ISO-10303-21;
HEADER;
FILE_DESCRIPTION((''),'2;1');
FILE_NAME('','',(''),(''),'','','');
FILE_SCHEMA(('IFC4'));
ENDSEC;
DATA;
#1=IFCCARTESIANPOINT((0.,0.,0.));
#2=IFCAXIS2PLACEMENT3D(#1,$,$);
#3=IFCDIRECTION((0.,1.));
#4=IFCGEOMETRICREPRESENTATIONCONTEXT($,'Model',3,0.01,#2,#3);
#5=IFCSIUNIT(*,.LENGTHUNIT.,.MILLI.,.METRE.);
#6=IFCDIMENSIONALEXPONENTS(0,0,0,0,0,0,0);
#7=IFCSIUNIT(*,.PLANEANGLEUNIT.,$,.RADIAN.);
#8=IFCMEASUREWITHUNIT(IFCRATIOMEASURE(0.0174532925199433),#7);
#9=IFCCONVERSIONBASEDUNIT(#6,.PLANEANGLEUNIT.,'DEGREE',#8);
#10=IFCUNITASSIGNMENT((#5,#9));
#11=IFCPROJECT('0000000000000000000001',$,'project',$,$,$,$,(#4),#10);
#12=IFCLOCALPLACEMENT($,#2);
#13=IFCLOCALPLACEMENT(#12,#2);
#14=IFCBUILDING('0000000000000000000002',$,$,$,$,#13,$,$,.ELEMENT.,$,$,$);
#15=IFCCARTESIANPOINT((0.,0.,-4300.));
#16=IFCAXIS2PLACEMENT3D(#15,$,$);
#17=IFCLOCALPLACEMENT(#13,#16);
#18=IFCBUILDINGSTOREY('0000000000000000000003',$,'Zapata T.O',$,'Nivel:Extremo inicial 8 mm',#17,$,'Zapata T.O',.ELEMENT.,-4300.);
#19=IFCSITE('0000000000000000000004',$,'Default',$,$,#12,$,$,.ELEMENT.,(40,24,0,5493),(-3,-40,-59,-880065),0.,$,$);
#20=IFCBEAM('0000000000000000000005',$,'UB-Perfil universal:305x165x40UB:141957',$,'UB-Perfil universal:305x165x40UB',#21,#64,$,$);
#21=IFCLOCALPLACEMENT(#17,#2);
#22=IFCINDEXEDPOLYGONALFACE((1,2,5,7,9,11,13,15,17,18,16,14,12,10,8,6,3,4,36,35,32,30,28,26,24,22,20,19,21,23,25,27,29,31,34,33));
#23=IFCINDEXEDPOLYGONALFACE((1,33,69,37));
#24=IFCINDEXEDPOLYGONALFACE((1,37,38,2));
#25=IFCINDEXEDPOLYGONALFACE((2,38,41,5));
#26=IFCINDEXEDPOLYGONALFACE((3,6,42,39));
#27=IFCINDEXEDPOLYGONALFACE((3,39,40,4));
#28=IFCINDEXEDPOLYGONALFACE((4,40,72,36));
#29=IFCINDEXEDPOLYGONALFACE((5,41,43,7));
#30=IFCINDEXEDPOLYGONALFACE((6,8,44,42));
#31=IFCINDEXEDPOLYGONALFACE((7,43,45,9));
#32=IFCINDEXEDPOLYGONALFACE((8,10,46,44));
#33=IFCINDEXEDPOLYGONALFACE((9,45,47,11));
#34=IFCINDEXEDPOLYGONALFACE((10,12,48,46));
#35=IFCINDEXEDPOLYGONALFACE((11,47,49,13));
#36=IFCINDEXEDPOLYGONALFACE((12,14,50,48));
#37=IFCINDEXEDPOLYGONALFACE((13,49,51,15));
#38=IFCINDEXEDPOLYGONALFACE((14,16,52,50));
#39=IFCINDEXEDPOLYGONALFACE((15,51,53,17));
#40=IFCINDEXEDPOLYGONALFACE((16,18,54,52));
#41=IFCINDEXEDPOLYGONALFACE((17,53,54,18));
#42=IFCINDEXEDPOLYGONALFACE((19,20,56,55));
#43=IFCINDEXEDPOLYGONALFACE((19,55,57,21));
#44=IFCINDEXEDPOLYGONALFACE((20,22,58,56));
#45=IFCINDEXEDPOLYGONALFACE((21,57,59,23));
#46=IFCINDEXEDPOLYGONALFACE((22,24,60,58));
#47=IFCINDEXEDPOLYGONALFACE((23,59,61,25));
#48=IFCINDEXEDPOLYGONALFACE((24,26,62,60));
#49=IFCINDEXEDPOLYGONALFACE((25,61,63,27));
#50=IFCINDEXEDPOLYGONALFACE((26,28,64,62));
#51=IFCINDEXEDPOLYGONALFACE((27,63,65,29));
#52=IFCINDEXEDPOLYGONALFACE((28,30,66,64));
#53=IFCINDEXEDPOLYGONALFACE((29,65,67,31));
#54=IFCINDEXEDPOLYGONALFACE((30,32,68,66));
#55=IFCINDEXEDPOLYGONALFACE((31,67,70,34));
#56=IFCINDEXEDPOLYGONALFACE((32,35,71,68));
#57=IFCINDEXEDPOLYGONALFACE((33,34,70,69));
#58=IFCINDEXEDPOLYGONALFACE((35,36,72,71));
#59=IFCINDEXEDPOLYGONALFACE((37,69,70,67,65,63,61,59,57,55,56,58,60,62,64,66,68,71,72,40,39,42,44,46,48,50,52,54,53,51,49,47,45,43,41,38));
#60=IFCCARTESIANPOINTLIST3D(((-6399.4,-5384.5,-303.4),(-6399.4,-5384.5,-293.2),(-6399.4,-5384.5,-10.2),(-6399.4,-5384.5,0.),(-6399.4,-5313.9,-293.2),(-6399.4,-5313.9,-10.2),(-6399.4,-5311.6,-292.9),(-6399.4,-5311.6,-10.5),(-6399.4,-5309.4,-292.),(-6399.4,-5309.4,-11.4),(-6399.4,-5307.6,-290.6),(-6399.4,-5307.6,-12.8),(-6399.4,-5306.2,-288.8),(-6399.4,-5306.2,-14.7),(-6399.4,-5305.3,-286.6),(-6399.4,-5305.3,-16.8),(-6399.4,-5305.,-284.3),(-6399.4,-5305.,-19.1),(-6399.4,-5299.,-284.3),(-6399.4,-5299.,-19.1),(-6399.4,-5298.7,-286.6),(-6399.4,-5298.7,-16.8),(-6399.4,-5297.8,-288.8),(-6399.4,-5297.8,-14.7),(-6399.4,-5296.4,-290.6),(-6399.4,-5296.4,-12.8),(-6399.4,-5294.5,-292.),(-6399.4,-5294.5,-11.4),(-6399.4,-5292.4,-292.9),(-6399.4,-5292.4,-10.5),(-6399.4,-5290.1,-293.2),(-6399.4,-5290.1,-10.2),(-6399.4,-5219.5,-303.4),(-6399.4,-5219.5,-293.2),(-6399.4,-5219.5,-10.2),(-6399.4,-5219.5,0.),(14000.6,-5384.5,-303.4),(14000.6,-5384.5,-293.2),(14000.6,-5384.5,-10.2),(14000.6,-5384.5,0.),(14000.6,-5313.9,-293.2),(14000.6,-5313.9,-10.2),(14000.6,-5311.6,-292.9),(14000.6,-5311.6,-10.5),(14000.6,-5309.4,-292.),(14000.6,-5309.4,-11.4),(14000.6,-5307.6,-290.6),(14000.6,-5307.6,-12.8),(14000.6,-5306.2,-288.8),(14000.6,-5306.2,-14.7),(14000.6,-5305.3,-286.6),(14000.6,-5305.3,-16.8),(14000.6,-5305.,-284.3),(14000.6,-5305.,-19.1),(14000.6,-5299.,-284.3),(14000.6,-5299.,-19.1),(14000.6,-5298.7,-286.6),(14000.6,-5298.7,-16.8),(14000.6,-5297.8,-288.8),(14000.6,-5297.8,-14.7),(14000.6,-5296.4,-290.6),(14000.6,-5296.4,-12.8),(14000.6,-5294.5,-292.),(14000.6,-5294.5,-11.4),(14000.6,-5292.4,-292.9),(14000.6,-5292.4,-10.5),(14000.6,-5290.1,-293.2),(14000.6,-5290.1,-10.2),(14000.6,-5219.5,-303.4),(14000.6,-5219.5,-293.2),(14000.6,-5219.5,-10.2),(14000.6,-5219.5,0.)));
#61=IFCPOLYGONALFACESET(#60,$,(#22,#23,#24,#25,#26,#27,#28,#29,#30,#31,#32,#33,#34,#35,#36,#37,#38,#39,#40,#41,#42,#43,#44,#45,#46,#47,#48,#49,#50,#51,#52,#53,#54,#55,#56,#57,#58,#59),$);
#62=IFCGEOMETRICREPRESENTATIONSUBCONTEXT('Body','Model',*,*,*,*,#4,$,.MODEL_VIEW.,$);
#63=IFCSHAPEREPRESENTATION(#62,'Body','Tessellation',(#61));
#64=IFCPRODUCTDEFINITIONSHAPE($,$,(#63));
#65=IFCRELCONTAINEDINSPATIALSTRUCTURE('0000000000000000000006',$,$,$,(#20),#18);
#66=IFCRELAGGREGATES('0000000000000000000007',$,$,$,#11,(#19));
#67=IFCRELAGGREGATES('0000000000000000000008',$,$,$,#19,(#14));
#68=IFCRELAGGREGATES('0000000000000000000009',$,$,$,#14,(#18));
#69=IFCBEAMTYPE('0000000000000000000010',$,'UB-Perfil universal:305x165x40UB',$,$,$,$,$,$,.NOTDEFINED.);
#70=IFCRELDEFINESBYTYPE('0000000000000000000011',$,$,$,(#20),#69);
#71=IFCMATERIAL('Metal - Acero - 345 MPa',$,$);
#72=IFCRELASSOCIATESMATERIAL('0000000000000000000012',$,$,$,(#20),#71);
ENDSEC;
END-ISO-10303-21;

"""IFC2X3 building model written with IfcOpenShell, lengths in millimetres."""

from ifc_helpers import new_model, entity, si_unit, converted_unit, direction, frame, frame_2d, origin, place, context, subcontext, project, spatial, i_section, extrude, material, type_object, element, save


model = new_model("IFC2X3")

# Units and contexts
model_context = context("Model", 3, precision=0.01, world=origin(), true_north=direction((0.0, 1.0)))
body_context = subcontext(model_context, "Body", "Model", "MODEL_VIEW")
ifc_project = project(units=[si_unit("LENGTHUNIT", "METRE", prefix="MILLI"), converted_unit("PLANEANGLEUNIT", "DEGREE", entity("IfcRatioMeasure", 0.0174532925199433), si_unit("PLANEANGLEUNIT", "RADIAN"), dimensions=[0, 0, 0, 0, 0, 0, 0])], contexts=[model_context])

# Site, building, storey
site_placement = place(None, origin())
site = spatial("IfcSite", under=ifc_project, at=site_placement, Name="Default", CompositionType="ELEMENT", RefLatitude=(40, 24, 0, 5493), RefLongitude=(-3, -40, -59, -880065), RefElevation=0.0)
building_placement = place(site_placement, origin())
building = spatial("IfcBuilding", under=site, at=building_placement, CompositionType="ELEMENT")
storey_placement = place(building_placement, frame((0.0, 0.0, -4300.0)))
storey = spatial("IfcBuildingStorey", under=building, at=storey_placement, Name="Zapata T.O", ObjectType="Nivel:Extremo inicial 8 mm", LongName="Zapata T.O", CompositionType="ELEMENT", Elevation=-4300.0)

# Beam
ifc_material = material(Name="Metal - Acero - 345 MPa")
beam_type = type_object("IfcBeamType", Name="UB-Perfil universal:305x165x40UB", PredefinedType="NOTDEFINED")
beam_placement = place(storey_placement, frame((-6399.4, -5302.0, 0.0)))
element("IfcBeam", 1, at=beam_placement, inside=storey, type_object=beam_type, material=ifc_material, Name="UB-Perfil universal:305x165x40UB:141957", ObjectType="UB-Perfil universal:305x165x40UB", context=body_context, shape_type="SweptSolid", body=[
    extrude(i_section(OverallWidth=165.0, OverallDepth=303.4, WebThickness=6.0, FlangeThickness=10.2, FilletRadius=8.9, at=frame_2d((0.0, 0.0), x_axis=(0.0, 1.0))), frame((0.0, 0.0, -151.7), z_axis=(1.0, 0.0, 0.0), x_axis=(0.0, 0.0, -1.0)), (0.0, 0.0, 1.0), 20400.0),
])

save(model, "model.ifc")
